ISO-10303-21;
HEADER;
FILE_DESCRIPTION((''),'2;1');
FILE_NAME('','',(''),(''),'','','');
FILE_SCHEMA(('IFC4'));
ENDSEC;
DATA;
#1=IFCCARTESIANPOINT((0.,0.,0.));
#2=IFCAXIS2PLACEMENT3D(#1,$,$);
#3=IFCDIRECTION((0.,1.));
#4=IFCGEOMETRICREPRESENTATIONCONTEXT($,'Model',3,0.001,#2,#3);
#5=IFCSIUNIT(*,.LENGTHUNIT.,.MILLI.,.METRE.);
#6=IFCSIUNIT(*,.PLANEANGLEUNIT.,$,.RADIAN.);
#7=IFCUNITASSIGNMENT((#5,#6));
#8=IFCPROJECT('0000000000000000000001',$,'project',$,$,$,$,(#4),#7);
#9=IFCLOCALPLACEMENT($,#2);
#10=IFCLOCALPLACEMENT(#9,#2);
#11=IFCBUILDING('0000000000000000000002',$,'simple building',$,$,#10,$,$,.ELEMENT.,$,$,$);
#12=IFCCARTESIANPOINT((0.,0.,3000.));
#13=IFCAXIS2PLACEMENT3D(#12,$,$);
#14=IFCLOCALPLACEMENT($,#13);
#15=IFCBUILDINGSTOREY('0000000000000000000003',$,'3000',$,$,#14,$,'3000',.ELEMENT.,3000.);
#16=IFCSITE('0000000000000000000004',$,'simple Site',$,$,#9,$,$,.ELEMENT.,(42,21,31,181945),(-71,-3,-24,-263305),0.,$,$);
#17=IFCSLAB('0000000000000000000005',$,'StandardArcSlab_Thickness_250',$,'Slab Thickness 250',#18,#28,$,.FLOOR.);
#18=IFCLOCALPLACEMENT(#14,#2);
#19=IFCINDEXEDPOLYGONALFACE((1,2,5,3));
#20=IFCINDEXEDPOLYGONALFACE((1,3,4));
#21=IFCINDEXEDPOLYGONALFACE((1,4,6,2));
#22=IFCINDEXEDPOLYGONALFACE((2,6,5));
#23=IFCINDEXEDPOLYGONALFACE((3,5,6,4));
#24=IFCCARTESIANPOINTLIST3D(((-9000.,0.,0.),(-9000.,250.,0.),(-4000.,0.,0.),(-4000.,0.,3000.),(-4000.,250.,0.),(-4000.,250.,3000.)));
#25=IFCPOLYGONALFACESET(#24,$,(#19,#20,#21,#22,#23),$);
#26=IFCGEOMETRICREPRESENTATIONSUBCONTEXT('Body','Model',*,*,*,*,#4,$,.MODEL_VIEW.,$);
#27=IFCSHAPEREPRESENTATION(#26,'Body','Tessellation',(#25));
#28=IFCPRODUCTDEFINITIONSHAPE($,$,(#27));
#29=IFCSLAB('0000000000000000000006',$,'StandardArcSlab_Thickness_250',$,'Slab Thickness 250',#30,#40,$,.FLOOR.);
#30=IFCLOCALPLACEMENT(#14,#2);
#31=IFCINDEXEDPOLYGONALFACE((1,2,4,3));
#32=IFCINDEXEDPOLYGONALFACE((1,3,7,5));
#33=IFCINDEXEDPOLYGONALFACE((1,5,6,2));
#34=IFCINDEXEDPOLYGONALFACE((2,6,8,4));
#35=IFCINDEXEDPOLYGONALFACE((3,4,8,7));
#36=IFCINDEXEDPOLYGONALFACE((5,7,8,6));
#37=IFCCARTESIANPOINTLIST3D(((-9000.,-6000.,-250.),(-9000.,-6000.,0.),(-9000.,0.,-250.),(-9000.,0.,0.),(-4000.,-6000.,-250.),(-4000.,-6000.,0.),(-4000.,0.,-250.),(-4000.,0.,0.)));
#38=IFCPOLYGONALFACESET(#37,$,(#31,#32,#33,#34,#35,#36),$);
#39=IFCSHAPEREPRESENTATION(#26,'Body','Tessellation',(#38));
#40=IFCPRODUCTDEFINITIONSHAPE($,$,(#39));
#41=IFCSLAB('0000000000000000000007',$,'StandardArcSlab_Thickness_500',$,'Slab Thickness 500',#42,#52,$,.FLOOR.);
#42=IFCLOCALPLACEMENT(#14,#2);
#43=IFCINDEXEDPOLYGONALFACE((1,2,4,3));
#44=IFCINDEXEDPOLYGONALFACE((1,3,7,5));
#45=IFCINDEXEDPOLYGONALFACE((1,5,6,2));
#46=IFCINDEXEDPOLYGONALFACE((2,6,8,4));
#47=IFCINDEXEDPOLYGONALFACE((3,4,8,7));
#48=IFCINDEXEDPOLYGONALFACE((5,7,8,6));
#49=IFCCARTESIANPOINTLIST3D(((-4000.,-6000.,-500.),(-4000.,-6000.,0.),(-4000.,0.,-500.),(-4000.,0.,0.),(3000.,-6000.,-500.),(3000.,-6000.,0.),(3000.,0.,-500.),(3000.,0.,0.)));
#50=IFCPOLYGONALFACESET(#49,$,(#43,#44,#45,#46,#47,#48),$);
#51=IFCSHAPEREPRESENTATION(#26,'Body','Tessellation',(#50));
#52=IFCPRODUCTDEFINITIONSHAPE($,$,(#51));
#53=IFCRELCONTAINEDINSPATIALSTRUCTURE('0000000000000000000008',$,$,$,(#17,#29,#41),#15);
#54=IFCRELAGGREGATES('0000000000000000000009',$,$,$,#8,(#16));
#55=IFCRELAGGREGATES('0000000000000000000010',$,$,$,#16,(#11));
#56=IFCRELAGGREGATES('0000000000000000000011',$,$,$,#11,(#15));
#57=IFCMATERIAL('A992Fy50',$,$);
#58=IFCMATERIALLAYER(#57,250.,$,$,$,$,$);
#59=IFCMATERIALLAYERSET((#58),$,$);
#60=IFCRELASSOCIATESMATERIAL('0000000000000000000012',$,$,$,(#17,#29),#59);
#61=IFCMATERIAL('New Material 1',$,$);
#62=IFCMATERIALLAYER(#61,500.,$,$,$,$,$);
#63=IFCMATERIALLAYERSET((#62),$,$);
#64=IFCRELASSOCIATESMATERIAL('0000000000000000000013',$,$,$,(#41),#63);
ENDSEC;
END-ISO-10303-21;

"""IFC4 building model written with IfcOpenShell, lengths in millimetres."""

from ifc_helpers import new_model, si_unit, direction, frame, origin, origin_with_axes, place, context, subcontext, project, spatial, polyline, outline, extrude, material, layer, layer_set, layer_usage, element, save


model = new_model("IFC4")

# Units and contexts
model_context = context("Model", 3, precision=0.001, world=origin(), true_north=direction((0.0, 1.0)))
body_context = subcontext(model_context, "Body", "Model", "MODEL_VIEW")
ifc_project = project(units=[si_unit("LENGTHUNIT", "METRE", prefix="MILLI"), si_unit("PLANEANGLEUNIT", "RADIAN")], contexts=[model_context])

# Site, building, storey
site_placement = place(None, origin())
site = spatial("IfcSite", under=ifc_project, at=site_placement, Name="simple Site", CompositionType="ELEMENT", RefLatitude=(42, 21, 31, 181945), RefLongitude=(-71, -3, -24, -263305), RefElevation=0.0)
building_placement = place(site_placement, origin())
building = spatial("IfcBuilding", under=site, at=building_placement, Name="simple building", CompositionType="ELEMENT")
storey_placement = place(None, frame((0.0, 0.0, 3000.0)))
storey = spatial("IfcBuildingStorey", under=building, at=storey_placement, Name="3000", LongName="3000", CompositionType="ELEMENT", Elevation=3000.0)

# Slabs
ifc_material_1 = material(Name="A992Fy50")
ifc_layer_1 = layer(ifc_material_1, 250.0)
ifc_layer_set_1 = layer_set([ifc_layer_1])
ifc_layer_usage_1 = layer_usage(ifc_layer_set_1, "AXIS3", "POSITIVE", -250.0)
slab_1_placement = place(None, frame((-9000.0, 250.0, 3000.0), z_axis=(0.0, -1.0, 0.0), x_axis=(1.0, 0.0, 0.0)))
element("IfcSlab", 1, at=slab_1_placement, inside=storey, material=ifc_layer_usage_1, Name="StandardArcSlab_Thickness_250", ObjectType="Slab Thickness 250", PredefinedType="FLOOR", context=body_context, shape_type="SweptSolid", body=[
    extrude(outline(polyline([(0.0, 0.0), (5000.0, 0.0), (5000.0, 3000.0), (0.0, 0.0)])), origin_with_axes(), (0.0, 0.0, 1.0), 250.0),
])
slab_2_placement = place(None, frame((-9000.0, 0.0, 2750.0), z_axis=(0.0, 0.0, 1.0), x_axis=(0.0, -1.0, 0.0)))
element("IfcSlab", 2, at=slab_2_placement, inside=storey, material=ifc_layer_usage_1, Name="StandardArcSlab_Thickness_250", ObjectType="Slab Thickness 250", PredefinedType="FLOOR", context=body_context, shape_type="SweptSolid", body=[
    extrude(outline(polyline([(0.0, 0.0), (6000.0, 0.0), (6000.0, 5000.0), (0.0, 5000.0), (0.0, 0.0)])), origin_with_axes(), (0.0, 0.0, 1.0), 250.0),
])
ifc_material_2 = material(Name="New Material 1")
ifc_layer_2 = layer(ifc_material_2, 500.0)
ifc_layer_set_2 = layer_set([ifc_layer_2])
ifc_layer_usage_2 = layer_usage(ifc_layer_set_2, "AXIS3", "POSITIVE", -500.0)
slab_3_placement = place(None, frame((-4000.0, -6000.0, 2500.0), z_axis=(0.0, 0.0, 1.0), x_axis=(1.0, 0.0, 0.0)))
element("IfcSlab", 3, at=slab_3_placement, inside=storey, material=ifc_layer_usage_2, Name="StandardArcSlab_Thickness_500", ObjectType="Slab Thickness 500", PredefinedType="FLOOR", context=body_context, shape_type="SweptSolid", body=[
    extrude(outline(polyline([(0.0, 0.0), (7000.0, 0.0), (7000.0, 6000.0), (0.0, 6000.0), (0.0, 0.0)])), origin_with_axes(), (0.0, 0.0, 1.0), 500.0),
])

save(model, "model.ifc")
